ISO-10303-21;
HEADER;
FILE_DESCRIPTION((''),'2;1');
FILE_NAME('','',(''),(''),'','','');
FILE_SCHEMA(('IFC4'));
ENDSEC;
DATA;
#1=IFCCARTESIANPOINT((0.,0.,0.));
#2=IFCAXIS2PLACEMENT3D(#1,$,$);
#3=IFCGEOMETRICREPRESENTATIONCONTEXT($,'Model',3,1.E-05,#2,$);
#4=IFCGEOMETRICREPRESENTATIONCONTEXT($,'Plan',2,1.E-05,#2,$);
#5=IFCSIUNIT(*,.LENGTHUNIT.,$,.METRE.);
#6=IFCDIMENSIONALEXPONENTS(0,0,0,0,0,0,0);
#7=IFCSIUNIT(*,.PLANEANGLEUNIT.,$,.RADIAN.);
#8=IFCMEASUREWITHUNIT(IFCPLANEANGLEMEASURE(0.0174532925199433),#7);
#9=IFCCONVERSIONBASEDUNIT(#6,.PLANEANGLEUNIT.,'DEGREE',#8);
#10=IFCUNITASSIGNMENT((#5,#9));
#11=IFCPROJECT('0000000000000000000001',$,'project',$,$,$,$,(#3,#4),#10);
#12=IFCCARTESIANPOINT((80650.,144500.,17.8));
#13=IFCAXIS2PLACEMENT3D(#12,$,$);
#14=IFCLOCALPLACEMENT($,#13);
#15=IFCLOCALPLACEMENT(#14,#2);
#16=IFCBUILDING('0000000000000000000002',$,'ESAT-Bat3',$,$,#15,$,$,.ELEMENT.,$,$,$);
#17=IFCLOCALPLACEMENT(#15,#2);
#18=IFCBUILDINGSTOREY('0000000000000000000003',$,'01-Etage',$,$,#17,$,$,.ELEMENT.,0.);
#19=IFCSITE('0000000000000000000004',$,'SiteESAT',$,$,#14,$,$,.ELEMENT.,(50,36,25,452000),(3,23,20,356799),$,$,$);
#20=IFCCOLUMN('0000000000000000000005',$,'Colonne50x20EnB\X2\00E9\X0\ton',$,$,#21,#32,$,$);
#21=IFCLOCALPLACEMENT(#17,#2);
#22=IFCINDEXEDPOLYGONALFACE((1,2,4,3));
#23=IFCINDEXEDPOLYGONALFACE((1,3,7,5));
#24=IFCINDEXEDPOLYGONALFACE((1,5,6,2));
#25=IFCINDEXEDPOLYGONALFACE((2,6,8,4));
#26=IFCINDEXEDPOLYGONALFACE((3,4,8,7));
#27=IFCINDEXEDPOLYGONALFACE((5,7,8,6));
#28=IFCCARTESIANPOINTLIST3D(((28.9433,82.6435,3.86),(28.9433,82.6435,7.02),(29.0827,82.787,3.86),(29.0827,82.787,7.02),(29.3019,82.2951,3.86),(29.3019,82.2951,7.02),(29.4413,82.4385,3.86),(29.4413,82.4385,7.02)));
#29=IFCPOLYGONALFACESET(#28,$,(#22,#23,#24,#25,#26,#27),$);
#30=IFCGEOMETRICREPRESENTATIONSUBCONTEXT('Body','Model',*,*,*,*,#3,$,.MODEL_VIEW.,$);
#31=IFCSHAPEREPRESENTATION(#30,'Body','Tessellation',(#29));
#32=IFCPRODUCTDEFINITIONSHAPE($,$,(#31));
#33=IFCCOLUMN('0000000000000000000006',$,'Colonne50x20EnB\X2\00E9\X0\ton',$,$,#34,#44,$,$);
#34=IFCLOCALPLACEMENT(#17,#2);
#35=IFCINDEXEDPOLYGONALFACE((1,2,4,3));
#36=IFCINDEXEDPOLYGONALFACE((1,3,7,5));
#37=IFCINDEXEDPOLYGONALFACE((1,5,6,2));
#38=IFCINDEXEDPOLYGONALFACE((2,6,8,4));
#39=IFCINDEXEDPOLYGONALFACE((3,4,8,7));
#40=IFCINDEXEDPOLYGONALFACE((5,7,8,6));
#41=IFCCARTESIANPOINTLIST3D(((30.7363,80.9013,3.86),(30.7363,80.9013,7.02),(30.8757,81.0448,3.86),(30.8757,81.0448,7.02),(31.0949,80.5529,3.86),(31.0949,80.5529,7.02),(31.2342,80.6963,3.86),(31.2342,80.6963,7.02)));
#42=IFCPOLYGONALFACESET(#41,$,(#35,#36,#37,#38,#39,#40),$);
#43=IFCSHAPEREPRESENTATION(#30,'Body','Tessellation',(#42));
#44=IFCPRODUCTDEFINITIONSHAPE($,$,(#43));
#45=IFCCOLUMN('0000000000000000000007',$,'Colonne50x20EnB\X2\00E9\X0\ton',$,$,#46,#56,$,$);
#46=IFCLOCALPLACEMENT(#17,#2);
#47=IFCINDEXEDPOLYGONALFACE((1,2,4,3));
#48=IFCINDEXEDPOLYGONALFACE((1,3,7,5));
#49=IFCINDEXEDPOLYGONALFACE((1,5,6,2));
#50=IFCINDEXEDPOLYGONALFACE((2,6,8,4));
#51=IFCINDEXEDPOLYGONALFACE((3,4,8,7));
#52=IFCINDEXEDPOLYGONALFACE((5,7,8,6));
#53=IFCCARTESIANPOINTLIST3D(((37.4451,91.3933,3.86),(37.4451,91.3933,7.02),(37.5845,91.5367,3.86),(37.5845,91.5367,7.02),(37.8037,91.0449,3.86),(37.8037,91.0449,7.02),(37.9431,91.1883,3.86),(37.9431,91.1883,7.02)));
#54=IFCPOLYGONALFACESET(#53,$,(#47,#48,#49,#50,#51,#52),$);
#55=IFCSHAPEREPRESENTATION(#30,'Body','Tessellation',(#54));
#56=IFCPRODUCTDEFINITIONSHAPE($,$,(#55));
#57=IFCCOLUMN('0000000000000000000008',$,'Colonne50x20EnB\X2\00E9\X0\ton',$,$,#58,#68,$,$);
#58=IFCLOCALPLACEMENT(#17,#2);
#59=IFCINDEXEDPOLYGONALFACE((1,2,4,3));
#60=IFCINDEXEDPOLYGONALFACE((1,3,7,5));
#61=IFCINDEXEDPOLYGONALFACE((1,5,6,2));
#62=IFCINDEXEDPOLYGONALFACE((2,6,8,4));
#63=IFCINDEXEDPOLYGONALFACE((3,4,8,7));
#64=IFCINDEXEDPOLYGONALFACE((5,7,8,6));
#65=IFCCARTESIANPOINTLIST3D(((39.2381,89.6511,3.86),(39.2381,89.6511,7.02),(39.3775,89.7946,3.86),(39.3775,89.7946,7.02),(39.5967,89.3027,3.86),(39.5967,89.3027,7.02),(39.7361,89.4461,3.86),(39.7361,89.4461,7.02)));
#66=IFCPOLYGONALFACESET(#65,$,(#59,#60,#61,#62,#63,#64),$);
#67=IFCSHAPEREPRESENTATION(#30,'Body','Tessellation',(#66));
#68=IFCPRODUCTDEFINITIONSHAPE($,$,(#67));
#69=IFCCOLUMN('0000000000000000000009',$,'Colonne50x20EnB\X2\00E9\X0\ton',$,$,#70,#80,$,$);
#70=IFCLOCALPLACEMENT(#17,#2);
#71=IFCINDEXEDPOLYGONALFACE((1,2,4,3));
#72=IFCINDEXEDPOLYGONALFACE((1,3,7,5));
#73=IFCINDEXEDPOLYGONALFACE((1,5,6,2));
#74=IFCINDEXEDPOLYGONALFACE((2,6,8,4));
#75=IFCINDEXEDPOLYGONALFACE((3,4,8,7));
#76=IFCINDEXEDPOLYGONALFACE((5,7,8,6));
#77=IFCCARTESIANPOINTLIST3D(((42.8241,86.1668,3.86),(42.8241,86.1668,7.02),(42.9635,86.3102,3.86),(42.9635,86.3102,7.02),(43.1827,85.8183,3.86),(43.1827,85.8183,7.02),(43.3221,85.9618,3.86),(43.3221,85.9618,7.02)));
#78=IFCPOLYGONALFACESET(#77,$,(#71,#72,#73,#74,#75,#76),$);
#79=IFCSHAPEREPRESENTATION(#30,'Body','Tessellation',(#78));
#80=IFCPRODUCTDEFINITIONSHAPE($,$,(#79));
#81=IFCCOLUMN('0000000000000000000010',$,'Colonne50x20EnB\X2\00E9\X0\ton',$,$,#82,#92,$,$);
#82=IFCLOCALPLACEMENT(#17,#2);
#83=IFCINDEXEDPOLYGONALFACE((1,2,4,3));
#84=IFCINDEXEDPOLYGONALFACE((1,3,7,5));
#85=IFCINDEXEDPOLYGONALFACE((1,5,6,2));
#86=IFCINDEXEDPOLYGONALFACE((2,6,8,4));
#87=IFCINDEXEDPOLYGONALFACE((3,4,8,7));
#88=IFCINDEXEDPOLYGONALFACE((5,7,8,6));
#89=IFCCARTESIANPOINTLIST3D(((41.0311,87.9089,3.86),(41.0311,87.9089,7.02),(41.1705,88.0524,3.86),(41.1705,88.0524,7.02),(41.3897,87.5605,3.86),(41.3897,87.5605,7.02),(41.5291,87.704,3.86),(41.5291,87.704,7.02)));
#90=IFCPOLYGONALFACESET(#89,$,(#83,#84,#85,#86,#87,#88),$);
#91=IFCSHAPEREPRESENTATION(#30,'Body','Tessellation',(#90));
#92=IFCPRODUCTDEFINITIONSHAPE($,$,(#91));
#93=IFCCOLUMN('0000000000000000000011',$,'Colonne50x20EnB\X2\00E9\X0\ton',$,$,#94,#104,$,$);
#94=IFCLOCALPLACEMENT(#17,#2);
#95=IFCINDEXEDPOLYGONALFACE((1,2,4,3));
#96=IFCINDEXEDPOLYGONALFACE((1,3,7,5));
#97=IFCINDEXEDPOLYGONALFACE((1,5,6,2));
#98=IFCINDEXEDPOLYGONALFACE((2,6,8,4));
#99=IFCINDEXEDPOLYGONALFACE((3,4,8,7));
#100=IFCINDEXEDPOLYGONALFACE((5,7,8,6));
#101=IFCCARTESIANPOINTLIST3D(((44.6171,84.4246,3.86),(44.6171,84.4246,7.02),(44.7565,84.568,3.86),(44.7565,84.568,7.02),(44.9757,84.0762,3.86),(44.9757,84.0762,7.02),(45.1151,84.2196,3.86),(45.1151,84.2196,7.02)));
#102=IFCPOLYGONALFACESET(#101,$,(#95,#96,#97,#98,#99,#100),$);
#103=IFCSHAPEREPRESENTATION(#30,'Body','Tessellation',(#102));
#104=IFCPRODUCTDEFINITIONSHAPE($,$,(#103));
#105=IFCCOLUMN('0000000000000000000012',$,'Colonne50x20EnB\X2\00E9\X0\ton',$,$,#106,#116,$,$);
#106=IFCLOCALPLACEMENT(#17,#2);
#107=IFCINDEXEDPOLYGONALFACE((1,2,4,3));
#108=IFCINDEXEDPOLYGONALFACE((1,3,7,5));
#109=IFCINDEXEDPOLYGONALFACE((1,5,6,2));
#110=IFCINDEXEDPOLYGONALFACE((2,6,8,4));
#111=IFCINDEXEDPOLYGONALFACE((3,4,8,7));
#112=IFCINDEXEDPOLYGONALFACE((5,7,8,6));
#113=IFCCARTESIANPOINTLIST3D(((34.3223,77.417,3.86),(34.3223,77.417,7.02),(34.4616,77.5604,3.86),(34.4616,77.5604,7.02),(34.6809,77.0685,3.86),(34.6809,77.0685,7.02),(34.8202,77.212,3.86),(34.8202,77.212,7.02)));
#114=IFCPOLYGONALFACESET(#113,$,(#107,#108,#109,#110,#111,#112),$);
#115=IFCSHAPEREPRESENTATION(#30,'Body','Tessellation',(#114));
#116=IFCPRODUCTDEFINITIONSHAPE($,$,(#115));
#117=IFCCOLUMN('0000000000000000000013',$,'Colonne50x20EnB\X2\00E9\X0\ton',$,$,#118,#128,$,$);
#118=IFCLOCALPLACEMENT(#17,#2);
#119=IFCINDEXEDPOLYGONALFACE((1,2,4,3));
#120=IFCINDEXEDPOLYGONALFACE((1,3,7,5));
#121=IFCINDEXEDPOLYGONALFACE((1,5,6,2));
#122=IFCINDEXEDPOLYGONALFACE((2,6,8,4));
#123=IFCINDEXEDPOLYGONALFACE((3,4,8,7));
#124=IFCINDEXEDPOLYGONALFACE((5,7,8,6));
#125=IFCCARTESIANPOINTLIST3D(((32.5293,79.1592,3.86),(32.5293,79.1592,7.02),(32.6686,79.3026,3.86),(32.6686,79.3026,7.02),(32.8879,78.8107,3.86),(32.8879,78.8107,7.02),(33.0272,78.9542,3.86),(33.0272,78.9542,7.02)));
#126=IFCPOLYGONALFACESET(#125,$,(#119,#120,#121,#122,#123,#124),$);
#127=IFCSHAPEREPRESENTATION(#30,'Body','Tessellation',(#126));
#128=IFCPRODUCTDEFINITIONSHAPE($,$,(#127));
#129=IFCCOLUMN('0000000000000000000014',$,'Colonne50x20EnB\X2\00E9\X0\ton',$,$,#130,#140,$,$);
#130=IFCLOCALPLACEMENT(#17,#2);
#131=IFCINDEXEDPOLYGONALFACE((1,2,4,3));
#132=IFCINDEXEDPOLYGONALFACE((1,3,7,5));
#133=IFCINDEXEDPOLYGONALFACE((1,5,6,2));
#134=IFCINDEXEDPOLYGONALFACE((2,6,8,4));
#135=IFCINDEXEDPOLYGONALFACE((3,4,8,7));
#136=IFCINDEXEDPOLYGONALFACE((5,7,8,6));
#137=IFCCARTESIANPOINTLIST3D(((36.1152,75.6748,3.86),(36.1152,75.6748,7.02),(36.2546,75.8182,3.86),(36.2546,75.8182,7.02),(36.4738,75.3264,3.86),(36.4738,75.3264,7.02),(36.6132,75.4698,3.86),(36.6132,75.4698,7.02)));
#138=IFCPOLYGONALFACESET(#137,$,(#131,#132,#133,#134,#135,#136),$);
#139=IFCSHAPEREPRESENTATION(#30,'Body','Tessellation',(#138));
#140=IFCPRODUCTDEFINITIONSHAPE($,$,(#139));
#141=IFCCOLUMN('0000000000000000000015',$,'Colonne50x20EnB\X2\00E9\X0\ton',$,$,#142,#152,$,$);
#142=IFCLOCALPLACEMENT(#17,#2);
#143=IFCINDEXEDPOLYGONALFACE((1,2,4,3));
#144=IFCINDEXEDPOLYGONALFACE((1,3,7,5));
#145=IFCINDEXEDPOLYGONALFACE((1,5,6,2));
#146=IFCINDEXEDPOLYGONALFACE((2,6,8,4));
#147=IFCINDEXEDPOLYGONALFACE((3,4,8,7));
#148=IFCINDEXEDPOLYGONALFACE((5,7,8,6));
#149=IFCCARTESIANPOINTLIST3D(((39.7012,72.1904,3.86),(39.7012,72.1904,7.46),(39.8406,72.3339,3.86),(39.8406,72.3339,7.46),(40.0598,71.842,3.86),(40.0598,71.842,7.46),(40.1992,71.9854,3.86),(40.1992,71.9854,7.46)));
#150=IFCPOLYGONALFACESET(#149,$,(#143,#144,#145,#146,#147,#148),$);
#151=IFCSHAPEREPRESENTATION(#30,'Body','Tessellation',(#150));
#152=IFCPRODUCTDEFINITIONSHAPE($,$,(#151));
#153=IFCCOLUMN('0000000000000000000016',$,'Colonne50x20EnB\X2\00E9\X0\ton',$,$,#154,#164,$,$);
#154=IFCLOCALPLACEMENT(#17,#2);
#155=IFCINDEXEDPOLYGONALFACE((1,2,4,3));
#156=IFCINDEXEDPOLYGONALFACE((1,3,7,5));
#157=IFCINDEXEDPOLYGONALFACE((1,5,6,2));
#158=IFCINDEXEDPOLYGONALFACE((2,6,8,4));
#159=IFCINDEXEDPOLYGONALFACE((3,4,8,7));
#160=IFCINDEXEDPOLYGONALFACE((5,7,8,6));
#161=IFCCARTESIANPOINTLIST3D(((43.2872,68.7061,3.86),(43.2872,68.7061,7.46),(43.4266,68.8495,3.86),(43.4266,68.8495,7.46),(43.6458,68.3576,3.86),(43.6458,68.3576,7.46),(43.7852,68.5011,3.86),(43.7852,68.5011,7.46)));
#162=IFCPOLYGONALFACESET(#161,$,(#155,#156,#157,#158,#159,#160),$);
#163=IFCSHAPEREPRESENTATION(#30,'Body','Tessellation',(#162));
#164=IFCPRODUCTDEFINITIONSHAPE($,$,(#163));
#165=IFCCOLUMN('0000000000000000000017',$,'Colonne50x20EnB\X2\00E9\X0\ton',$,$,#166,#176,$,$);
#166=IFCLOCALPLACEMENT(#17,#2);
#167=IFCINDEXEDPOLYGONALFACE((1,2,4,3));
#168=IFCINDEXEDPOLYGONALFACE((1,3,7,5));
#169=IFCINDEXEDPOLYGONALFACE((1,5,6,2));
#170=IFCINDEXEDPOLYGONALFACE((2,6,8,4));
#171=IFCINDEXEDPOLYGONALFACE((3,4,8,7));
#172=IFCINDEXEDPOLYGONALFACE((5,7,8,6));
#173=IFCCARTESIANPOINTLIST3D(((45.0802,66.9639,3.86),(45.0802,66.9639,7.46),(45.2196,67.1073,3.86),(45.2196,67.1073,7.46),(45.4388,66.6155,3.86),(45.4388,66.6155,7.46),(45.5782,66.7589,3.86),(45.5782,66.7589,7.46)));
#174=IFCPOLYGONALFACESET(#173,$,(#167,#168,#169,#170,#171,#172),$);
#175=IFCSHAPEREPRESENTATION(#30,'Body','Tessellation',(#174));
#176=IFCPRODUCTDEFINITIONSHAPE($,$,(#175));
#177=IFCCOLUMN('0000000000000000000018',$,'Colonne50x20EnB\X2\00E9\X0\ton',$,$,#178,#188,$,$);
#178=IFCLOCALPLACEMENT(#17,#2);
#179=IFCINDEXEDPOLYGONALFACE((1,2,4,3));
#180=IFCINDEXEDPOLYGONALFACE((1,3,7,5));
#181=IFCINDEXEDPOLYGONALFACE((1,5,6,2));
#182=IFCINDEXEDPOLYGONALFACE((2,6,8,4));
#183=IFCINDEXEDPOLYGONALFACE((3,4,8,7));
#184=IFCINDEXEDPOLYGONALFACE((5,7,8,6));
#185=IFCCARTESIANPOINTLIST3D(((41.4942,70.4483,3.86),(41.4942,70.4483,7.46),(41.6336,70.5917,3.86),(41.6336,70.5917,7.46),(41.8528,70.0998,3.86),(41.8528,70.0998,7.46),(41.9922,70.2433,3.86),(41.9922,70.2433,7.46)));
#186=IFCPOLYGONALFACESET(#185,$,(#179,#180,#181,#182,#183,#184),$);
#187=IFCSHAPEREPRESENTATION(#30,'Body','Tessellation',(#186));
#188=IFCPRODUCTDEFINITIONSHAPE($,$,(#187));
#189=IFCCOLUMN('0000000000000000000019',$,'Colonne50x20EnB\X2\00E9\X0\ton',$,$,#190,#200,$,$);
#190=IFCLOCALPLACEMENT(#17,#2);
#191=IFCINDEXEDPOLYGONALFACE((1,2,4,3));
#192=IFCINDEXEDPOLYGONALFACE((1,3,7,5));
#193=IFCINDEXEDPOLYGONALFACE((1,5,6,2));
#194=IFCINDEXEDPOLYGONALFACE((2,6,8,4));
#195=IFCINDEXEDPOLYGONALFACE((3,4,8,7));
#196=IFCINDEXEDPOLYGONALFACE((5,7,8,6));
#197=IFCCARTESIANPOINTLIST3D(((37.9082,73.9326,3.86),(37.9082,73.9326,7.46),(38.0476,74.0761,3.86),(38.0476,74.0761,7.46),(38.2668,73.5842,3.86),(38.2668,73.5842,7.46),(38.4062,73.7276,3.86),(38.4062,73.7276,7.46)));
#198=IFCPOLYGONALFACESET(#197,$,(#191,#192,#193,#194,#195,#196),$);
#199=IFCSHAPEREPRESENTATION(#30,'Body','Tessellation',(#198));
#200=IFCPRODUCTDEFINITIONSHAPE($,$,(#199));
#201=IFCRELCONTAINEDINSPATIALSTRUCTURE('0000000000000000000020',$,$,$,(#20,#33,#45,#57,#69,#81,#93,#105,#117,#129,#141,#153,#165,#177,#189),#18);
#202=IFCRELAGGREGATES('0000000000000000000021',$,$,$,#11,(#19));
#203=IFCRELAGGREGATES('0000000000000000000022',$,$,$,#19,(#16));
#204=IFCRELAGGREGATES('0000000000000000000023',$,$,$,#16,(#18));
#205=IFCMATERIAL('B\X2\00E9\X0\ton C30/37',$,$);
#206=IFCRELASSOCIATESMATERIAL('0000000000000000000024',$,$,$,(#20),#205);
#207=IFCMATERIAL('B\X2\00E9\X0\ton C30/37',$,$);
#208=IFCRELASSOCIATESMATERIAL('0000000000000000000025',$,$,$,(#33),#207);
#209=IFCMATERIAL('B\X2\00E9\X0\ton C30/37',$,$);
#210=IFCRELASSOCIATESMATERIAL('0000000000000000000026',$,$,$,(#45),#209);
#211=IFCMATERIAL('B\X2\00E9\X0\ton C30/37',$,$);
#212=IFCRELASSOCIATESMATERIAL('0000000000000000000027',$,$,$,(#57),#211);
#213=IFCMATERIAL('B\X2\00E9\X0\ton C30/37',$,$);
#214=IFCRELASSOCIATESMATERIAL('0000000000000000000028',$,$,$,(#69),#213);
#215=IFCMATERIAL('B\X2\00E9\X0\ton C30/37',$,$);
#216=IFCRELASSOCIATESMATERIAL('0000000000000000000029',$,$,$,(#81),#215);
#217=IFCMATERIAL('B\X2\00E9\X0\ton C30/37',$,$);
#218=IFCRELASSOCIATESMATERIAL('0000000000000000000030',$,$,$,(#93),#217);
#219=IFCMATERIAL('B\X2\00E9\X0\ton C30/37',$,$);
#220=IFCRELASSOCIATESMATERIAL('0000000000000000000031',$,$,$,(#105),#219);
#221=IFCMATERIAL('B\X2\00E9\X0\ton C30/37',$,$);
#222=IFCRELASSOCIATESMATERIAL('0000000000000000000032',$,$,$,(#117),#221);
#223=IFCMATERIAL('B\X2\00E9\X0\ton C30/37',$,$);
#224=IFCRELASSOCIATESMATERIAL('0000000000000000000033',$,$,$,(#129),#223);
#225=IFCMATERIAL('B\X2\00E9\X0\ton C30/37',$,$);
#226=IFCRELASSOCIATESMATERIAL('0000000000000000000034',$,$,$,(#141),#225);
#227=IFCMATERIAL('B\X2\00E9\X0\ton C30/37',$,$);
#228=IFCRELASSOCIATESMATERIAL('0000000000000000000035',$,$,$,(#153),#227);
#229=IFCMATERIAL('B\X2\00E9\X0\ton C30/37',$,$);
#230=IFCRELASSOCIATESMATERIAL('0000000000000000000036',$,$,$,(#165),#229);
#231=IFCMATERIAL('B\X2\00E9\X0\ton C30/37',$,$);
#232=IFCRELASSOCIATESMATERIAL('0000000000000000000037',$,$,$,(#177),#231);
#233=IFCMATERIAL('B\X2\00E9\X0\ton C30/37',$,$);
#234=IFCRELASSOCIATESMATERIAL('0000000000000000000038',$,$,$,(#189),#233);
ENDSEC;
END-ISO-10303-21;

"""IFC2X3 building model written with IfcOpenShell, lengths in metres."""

from ifc_helpers import new_model, entity, si_unit, converted_unit, frame, frame_2d, origin, origin_with_axes, place, context, subcontext, project, spatial, rectangle, extrude, material, element, save


model = new_model("IFC2X3")

# Units and contexts
model_context = context("Model", 3, precision=1e-05, world=origin())
plan_context = context("Plan", 2, precision=1e-05, world=origin())
body_context = subcontext(model_context, "Body", "Model", "MODEL_VIEW")
ifc_project = project(units=[si_unit("LENGTHUNIT", "METRE"), converted_unit("PLANEANGLEUNIT", "DEGREE", entity("IfcPlaneAngleMeasure", 0.0174532925199433), si_unit("PLANEANGLEUNIT", "RADIAN"), dimensions=[0, 0, 0, 0, 0, 0, 0])], contexts=[model_context, plan_context])

# Site, building, storey
site_placement = place(None, frame((80650.0, 144500.0, 17.8)))
site = spatial("IfcSite", under=ifc_project, at=site_placement, Name="SiteESAT", CompositionType="ELEMENT", RefLatitude=(50, 36, 25, 452000), RefLongitude=(3, 23, 20, 356799))
building_placement = place(site_placement, origin())
building = spatial("IfcBuilding", under=site, at=building_placement, Name="ESAT-Bat3", CompositionType="ELEMENT")
storey_placement = place(building_placement, origin())
storey = spatial("IfcBuildingStorey", under=building, at=storey_placement, Name="01-Etage", CompositionType="ELEMENT", Elevation=0.0)

# Columns
ifc_material_1 = material(Name="Béton C30/37")
column_1_placement = place(storey_placement, frame((29.4413, 82.4385, 3.86)))
element("IfcColumn", 1, at=column_1_placement, inside=storey, material=ifc_material_1, Name="Colonne50x20EnBéton", context=body_context, shape_type="SweptSolid", body=[
    extrude(rectangle(XDim=0.5, YDim=0.2, at=frame_2d((-0.249, 0.1025), x_axis=(-0.717196, 0.696872))), origin_with_axes(), (0.0, 0.0, 1.0), 3.16),
])
ifc_material_2 = material(Name="Béton C30/37")
column_2_placement = place(storey_placement, frame((31.2342, 80.6963, 3.86)))
element("IfcColumn", 2, at=column_2_placement, inside=storey, material=ifc_material_2, Name="Colonne50x20EnBéton", context=body_context, shape_type="SweptSolid", body=[
    extrude(rectangle(XDim=0.5, YDim=0.2, at=frame_2d((-0.249, 0.1025), x_axis=(-0.717196, 0.696872))), origin_with_axes(), (0.0, 0.0, 1.0), 3.16),
])
ifc_material_3 = material(Name="Béton C30/37")
column_3_placement = place(storey_placement, frame((37.9431, 91.1883, 3.86)))
element("IfcColumn", 3, at=column_3_placement, inside=storey, material=ifc_material_3, Name="Colonne50x20EnBéton", context=body_context, shape_type="SweptSolid", body=[
    extrude(rectangle(XDim=0.5, YDim=0.2, at=frame_2d((-0.249, 0.1025), x_axis=(-0.717196, 0.696872))), origin_with_axes(), (0.0, 0.0, 1.0), 3.16),
])
ifc_material_4 = material(Name="Béton C30/37")
column_4_placement = place(storey_placement, frame((39.7361, 89.4461, 3.86)))
element("IfcColumn", 4, at=column_4_placement, inside=storey, material=ifc_material_4, Name="Colonne50x20EnBéton", context=body_context, shape_type="SweptSolid", body=[
    extrude(rectangle(XDim=0.5, YDim=0.2, at=frame_2d((-0.249, 0.1025), x_axis=(-0.717196, 0.696872))), origin_with_axes(), (0.0, 0.0, 1.0), 3.16),
])
ifc_material_5 = material(Name="Béton C30/37")
column_5_placement = place(storey_placement, frame((43.3221, 85.9618, 3.86)))
element("IfcColumn", 5, at=column_5_placement, inside=storey, material=ifc_material_5, Name="Colonne50x20EnBéton", context=body_context, shape_type="SweptSolid", body=[
    extrude(rectangle(XDim=0.5, YDim=0.2, at=frame_2d((-0.249, 0.1025), x_axis=(-0.717196, 0.696872))), origin_with_axes(), (0.0, 0.0, 1.0), 3.16),
])
ifc_material_6 = material(Name="Béton C30/37")
column_6_placement = place(storey_placement, frame((41.5291, 87.704, 3.86)))
element("IfcColumn", 6, at=column_6_placement, inside=storey, material=ifc_material_6, Name="Colonne50x20EnBéton", context=body_context, shape_type="SweptSolid", body=[
    extrude(rectangle(XDim=0.5, YDim=0.2, at=frame_2d((-0.249, 0.1025), x_axis=(-0.717196, 0.696872))), origin_with_axes(), (0.0, 0.0, 1.0), 3.16),
])
ifc_material_7 = material(Name="Béton C30/37")
column_7_placement = place(storey_placement, frame((45.1151, 84.2196, 3.86)))
element("IfcColumn", 7, at=column_7_placement, inside=storey, material=ifc_material_7, Name="Colonne50x20EnBéton", context=body_context, shape_type="SweptSolid", body=[
    extrude(rectangle(XDim=0.5, YDim=0.2, at=frame_2d((-0.249, 0.1025), x_axis=(-0.717196, 0.696872))), origin_with_axes(), (0.0, 0.0, 1.0), 3.16),
])
ifc_material_8 = material(Name="Béton C30/37")
column_8_placement = place(storey_placement, frame((34.8202, 77.212, 3.86)))
element("IfcColumn", 8, at=column_8_placement, inside=storey, material=ifc_material_8, Name="Colonne50x20EnBéton", context=body_context, shape_type="SweptSolid", body=[
    extrude(rectangle(XDim=0.5, YDim=0.2, at=frame_2d((-0.249, 0.1025), x_axis=(-0.717196, 0.696872))), origin_with_axes(), (0.0, 0.0, 1.0), 3.16),
])
ifc_material_9 = material(Name="Béton C30/37")
column_9_placement = place(storey_placement, frame((33.0272, 78.9542, 3.86)))
element("IfcColumn", 9, at=column_9_placement, inside=storey, material=ifc_material_9, Name="Colonne50x20EnBéton", context=body_context, shape_type="SweptSolid", body=[
    extrude(rectangle(XDim=0.5, YDim=0.2, at=frame_2d((-0.249, 0.1025), x_axis=(-0.717196, 0.696872))), origin_with_axes(), (0.0, 0.0, 1.0), 3.16),
])
ifc_material_10 = material(Name="Béton C30/37")
column_10_placement = place(storey_placement, frame((36.6132, 75.4698, 3.86)))
element("IfcColumn", 10, at=column_10_placement, inside=storey, material=ifc_material_10, Name="Colonne50x20EnBéton", context=body_context, shape_type="SweptSolid", body=[
    extrude(rectangle(XDim=0.5, YDim=0.2, at=frame_2d((-0.249, 0.1025), x_axis=(-0.717196, 0.696872))), origin_with_axes(), (0.0, 0.0, 1.0), 3.16),
])
ifc_material_11 = material(Name="Béton C30/37")
column_11_placement = place(storey_placement, frame((40.1992, 71.9854, 3.86)))
element("IfcColumn", 11, at=column_11_placement, inside=storey, material=ifc_material_11, Name="Colonne50x20EnBéton", context=body_context, shape_type="SweptSolid", body=[
    extrude(rectangle(XDim=0.5, YDim=0.2, at=frame_2d((-0.249, 0.1025), x_axis=(-0.717196, 0.696872))), origin_with_axes(), (0.0, 0.0, 1.0), 3.6),
])
ifc_material_12 = material(Name="Béton C30/37")
column_12_placement = place(storey_placement, frame((43.7852, 68.5011, 3.86)))
element("IfcColumn", 12, at=column_12_placement, inside=storey, material=ifc_material_12, Name="Colonne50x20EnBéton", context=body_context, shape_type="SweptSolid", body=[
    extrude(rectangle(XDim=0.5, YDim=0.2, at=frame_2d((-0.249, 0.1025), x_axis=(-0.717196, 0.696872))), origin_with_axes(), (0.0, 0.0, 1.0), 3.6),
])
ifc_material_13 = material(Name="Béton C30/37")
column_13_placement = place(storey_placement, frame((45.5782, 66.7589, 3.86)))
element("IfcColumn", 13, at=column_13_placement, inside=storey, material=ifc_material_13, Name="Colonne50x20EnBéton", context=body_context, shape_type="SweptSolid", body=[
    extrude(rectangle(XDim=0.5, YDim=0.2, at=frame_2d((-0.249, 0.1025), x_axis=(-0.717196, 0.696872))), origin_with_axes(), (0.0, 0.0, 1.0), 3.6),
])
ifc_material_14 = material(Name="Béton C30/37")
column_14_placement = place(storey_placement, frame((41.9922, 70.2433, 3.86)))
element("IfcColumn", 14, at=column_14_placement, inside=storey, material=ifc_material_14, Name="Colonne50x20EnBéton", context=body_context, shape_type="SweptSolid", body=[
    extrude(rectangle(XDim=0.5, YDim=0.2, at=frame_2d((-0.249, 0.1025), x_axis=(-0.717196, 0.696872))), origin_with_axes(), (0.0, 0.0, 1.0), 3.6),
])
ifc_material_15 = material(Name="Béton C30/37")
column_15_placement = place(storey_placement, frame((38.4062, 73.7276, 3.86)))
element("IfcColumn", 15, at=column_15_placement, inside=storey, material=ifc_material_15, Name="Colonne50x20EnBéton", context=body_context, shape_type="SweptSolid", body=[
    extrude(rectangle(XDim=0.5, YDim=0.2, at=frame_2d((-0.249, 0.1025), x_axis=(-0.717196, 0.696872))), origin_with_axes(), (0.0, 0.0, 1.0), 3.6),
])

save(model, "model.ifc")
